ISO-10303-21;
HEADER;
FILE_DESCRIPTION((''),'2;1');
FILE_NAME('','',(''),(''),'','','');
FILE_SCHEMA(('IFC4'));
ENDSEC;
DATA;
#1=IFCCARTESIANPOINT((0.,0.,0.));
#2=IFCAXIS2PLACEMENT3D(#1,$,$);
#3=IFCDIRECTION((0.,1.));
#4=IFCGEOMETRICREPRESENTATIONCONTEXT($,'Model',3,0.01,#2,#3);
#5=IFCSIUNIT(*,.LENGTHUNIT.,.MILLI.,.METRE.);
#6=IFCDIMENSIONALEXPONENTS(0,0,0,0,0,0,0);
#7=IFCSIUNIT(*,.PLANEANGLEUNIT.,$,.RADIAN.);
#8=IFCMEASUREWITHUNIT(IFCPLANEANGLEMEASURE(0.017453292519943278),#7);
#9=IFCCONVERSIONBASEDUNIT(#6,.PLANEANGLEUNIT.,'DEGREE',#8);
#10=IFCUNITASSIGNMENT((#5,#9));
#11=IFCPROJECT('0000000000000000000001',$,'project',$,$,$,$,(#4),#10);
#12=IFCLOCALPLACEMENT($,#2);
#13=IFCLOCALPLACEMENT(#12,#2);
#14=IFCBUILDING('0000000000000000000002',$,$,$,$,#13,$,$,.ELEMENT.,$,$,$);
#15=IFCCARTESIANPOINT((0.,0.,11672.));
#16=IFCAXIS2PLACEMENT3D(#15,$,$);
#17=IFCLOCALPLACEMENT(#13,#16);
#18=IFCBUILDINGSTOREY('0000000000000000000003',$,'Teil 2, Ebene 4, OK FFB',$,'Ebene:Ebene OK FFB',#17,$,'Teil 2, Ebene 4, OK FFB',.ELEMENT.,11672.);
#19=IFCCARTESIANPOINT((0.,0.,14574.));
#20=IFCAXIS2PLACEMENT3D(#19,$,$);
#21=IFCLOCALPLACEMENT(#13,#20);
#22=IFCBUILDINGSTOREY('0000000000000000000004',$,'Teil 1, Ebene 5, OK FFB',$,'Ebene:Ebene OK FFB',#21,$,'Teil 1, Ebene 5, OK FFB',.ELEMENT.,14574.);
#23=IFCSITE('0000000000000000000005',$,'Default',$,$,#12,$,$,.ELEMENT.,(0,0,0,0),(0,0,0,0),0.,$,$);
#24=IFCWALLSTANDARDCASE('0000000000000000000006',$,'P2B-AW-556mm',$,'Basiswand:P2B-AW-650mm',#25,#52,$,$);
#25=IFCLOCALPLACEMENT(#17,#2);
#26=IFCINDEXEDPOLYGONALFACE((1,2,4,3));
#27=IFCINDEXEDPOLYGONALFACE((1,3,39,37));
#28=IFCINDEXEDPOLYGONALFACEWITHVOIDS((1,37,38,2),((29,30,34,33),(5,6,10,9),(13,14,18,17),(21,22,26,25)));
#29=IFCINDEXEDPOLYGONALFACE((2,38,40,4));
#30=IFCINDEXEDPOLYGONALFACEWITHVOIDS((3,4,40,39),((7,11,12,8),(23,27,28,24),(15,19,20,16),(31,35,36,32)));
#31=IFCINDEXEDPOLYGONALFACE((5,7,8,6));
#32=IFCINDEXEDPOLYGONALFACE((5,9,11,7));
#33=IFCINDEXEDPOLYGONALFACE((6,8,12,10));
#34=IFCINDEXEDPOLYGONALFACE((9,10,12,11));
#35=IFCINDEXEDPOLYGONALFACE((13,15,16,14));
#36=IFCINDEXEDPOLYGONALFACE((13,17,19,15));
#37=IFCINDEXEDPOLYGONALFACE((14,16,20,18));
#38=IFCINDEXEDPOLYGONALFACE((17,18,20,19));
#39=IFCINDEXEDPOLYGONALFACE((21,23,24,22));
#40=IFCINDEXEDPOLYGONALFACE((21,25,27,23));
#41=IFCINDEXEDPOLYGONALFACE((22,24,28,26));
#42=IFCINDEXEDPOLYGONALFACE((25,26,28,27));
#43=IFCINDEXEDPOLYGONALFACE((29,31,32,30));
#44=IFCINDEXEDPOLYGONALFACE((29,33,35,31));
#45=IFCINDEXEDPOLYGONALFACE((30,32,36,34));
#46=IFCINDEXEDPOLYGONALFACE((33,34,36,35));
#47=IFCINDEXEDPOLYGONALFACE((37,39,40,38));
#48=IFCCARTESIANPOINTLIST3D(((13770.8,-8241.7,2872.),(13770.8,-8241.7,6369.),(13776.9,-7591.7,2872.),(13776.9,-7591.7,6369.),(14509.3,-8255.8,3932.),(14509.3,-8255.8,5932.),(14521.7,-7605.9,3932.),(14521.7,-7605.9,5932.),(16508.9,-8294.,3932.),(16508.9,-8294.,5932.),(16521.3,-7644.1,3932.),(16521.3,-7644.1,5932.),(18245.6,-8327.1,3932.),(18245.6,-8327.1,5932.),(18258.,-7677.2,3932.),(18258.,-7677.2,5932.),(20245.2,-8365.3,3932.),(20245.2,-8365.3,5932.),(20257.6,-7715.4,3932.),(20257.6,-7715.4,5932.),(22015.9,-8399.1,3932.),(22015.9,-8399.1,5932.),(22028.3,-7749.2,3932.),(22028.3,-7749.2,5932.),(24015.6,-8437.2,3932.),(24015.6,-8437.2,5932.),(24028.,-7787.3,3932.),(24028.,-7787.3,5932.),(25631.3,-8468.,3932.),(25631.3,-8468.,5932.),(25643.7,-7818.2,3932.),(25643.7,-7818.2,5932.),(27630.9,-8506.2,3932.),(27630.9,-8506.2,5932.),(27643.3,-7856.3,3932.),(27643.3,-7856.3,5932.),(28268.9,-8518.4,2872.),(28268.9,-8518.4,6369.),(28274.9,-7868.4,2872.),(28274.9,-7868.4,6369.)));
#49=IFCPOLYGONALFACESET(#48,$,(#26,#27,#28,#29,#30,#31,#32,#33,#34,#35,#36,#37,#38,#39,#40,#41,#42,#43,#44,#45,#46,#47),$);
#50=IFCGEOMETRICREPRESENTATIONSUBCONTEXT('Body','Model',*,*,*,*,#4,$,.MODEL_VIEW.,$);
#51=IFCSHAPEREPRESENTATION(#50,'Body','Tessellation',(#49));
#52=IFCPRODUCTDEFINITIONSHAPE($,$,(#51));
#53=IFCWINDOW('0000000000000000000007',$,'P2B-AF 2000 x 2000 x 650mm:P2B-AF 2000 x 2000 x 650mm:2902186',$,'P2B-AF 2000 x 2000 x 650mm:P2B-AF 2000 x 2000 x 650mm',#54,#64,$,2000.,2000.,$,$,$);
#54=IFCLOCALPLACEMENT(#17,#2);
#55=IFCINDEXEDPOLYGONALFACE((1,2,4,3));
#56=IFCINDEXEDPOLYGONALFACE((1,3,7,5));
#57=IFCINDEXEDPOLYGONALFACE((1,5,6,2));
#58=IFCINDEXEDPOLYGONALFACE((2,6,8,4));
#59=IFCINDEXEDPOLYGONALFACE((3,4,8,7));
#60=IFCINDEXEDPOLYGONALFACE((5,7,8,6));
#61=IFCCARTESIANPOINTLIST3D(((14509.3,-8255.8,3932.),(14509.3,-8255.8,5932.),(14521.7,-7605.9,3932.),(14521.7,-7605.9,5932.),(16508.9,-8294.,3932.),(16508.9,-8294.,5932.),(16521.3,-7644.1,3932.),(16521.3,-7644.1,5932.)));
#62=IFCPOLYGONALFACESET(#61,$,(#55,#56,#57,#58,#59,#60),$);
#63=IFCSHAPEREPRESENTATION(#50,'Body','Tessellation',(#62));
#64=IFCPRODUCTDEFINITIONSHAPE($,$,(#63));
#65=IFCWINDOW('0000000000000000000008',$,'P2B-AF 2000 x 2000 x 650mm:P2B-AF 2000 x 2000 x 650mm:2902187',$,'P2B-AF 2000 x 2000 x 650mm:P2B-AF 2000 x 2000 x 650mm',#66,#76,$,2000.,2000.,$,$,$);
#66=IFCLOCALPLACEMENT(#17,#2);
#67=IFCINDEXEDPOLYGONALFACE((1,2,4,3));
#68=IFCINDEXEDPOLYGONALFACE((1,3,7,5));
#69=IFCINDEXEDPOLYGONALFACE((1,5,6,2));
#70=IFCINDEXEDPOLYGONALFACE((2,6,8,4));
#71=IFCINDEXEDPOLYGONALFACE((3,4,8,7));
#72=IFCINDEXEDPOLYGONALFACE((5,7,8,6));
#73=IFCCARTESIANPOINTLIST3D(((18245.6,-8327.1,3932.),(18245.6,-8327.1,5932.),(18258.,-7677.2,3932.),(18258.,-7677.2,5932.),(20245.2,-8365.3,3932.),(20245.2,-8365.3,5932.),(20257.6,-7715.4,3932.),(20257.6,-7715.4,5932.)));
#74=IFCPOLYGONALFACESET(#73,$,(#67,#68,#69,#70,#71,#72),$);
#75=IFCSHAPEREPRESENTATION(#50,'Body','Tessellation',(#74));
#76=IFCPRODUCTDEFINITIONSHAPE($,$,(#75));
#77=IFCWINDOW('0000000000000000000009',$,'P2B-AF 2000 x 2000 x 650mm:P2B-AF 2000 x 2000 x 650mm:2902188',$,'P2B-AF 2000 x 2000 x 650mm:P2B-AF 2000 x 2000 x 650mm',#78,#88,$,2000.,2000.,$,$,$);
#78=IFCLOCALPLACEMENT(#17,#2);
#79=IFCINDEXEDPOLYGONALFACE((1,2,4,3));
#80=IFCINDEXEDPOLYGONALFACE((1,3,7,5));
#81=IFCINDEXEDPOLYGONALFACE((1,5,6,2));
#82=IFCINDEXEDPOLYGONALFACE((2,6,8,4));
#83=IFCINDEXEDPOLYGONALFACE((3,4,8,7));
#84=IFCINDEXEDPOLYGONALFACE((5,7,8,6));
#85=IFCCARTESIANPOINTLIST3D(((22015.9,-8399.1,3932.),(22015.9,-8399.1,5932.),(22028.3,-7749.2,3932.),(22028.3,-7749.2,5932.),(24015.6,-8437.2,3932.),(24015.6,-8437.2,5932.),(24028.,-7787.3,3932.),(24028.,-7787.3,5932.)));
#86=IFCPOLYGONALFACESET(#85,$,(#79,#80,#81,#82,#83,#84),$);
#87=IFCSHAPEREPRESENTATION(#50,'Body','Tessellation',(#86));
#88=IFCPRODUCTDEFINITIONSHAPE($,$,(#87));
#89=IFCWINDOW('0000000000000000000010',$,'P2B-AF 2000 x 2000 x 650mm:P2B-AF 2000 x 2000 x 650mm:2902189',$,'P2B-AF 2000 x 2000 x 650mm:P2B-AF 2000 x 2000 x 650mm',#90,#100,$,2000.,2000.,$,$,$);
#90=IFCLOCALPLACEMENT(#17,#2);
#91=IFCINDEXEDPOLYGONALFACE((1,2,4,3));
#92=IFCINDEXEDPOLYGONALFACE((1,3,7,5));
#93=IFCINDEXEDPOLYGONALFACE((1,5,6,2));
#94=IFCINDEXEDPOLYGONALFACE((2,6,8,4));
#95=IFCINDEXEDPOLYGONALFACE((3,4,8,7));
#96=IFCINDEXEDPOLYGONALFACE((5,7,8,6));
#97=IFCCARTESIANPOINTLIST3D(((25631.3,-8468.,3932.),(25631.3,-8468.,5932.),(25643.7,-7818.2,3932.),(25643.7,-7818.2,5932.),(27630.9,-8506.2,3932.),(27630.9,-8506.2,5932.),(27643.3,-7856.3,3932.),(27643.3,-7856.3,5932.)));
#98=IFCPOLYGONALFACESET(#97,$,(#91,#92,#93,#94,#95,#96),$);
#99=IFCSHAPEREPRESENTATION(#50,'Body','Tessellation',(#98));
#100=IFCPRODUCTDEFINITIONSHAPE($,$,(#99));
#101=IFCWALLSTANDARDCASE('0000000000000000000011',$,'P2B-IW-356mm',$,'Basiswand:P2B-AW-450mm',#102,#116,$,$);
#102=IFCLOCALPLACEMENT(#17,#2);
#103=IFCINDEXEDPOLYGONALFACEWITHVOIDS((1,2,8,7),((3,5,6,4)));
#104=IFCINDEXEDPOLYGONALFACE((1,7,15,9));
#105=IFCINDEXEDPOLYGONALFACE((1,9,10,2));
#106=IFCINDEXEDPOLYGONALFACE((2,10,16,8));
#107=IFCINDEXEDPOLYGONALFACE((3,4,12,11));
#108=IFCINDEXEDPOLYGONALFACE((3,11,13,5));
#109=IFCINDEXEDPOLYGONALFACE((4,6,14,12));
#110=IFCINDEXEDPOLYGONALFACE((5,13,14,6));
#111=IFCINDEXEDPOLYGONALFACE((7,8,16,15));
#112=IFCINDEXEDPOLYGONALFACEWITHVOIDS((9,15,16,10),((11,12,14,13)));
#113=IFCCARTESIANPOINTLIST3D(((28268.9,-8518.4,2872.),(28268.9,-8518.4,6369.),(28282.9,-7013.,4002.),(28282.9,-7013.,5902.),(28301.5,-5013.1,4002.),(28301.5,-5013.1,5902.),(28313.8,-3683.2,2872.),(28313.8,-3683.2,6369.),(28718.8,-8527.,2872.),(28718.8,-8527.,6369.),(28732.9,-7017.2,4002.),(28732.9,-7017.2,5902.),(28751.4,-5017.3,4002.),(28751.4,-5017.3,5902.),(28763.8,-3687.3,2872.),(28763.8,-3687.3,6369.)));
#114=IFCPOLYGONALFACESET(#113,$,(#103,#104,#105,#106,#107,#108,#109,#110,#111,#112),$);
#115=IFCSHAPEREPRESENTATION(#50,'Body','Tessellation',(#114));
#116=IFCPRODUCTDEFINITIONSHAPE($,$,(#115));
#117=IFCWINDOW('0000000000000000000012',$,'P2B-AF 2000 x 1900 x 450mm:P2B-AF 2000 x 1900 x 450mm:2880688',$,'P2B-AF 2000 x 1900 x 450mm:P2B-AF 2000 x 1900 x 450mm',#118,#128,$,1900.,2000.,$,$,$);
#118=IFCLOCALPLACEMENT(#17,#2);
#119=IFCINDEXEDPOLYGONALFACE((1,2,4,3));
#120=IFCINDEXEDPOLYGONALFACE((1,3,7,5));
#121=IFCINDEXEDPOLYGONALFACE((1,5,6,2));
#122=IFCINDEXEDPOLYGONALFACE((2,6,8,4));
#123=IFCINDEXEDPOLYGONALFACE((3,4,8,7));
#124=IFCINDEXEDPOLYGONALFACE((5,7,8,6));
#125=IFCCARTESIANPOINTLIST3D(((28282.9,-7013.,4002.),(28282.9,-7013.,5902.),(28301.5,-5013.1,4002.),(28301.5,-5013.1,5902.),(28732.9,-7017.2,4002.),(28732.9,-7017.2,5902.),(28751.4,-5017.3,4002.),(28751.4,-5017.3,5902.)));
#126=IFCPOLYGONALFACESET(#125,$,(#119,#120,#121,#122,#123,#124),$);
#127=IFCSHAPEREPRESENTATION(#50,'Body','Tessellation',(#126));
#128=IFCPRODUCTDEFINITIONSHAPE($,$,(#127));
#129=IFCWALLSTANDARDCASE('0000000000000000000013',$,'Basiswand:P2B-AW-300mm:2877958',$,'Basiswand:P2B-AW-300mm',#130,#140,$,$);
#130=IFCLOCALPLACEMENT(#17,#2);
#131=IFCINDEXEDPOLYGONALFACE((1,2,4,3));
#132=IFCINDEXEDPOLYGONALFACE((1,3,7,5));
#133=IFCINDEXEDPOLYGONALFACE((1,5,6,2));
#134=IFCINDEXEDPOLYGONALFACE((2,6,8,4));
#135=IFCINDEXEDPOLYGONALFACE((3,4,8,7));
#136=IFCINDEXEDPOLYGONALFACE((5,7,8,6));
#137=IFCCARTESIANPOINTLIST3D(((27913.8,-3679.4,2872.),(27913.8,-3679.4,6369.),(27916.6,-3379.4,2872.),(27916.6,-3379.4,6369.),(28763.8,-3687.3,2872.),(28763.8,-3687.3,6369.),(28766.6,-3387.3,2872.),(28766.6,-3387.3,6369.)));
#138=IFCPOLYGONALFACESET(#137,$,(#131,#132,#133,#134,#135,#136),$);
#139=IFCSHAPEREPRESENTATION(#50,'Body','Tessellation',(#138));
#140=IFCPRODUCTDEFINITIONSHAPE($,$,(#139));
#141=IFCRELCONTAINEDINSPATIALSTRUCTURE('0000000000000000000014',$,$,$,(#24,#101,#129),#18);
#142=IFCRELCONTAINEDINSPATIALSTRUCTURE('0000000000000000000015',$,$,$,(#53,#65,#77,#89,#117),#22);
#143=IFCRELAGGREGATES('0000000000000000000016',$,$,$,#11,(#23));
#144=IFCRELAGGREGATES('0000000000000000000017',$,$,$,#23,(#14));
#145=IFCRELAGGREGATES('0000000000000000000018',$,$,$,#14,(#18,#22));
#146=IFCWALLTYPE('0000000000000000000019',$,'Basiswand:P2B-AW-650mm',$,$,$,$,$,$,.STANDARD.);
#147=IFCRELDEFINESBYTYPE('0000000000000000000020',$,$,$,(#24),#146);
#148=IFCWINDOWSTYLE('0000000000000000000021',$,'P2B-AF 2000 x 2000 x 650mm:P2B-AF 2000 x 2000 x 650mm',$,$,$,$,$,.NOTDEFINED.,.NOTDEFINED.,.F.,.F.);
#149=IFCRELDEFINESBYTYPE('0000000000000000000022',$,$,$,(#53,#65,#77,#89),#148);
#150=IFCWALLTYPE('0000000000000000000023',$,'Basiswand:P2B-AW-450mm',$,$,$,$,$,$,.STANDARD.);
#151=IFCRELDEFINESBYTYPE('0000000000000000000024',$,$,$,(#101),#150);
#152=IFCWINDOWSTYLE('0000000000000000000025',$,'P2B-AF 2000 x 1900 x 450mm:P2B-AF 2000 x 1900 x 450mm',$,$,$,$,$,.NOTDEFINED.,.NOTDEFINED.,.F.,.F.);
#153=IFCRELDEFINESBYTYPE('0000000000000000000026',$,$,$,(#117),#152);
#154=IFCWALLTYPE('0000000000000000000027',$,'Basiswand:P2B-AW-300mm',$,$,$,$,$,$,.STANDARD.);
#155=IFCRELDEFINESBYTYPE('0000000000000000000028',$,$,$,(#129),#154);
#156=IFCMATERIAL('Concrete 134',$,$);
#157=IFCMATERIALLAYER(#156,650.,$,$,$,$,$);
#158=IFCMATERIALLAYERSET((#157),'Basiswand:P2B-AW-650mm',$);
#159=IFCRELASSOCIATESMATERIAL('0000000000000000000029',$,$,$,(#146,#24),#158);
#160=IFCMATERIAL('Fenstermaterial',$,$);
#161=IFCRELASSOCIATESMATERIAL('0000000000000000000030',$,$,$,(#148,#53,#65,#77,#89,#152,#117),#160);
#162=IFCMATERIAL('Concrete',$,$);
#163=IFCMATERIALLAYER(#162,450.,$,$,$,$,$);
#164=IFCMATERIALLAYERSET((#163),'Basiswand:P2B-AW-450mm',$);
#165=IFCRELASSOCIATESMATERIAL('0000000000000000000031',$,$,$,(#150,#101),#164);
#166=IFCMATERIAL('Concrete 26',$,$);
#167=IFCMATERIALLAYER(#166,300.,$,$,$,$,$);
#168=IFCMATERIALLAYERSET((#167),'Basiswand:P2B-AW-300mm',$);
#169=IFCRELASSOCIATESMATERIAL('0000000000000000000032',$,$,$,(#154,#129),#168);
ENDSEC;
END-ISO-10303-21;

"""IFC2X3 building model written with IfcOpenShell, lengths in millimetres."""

from ifc_helpers import new_model, entity, si_unit, converted_unit, direction, frame, frame_2d, origin, origin_2d_with_axis, place, context, subcontext, project, spatial, polyline, rectangle, outline, extrude, source, transform, mapped, material, layer, layer_set, layer_usage, type_object, type_shapes, element, fill, save


model = new_model("IFC2X3")

# Units and contexts
model_context = context("Model", 3, precision=0.01, world=origin(), true_north=direction((0.0, 1.0)))
body_context = subcontext(model_context, "Body", "Model", "MODEL_VIEW")
ifc_project = project(units=[si_unit("LENGTHUNIT", "METRE", prefix="MILLI"), converted_unit("PLANEANGLEUNIT", "DEGREE", entity("IfcPlaneAngleMeasure", 0.017453292519943278), si_unit("PLANEANGLEUNIT", "RADIAN"), dimensions=[0, 0, 0, 0, 0, 0, 0])], contexts=[model_context])

# Site, building, storey
site_placement = place(None, origin())
site = spatial("IfcSite", under=ifc_project, at=site_placement, Name="Default", CompositionType="ELEMENT", RefLatitude=(0, 0, 0, 0), RefLongitude=(0, 0, 0, 0), RefElevation=0.0)
building_placement = place(site_placement, origin())
building = spatial("IfcBuilding", under=site, at=building_placement, CompositionType="ELEMENT")
storey_1_placement = place(building_placement, frame((0.0, 0.0, 11672.0)))
storey_1 = spatial("IfcBuildingStorey", under=building, at=storey_1_placement, Name="Teil 2, Ebene 4, OK FFB", ObjectType="Ebene:Ebene OK FFB", LongName="Teil 2, Ebene 4, OK FFB", CompositionType="ELEMENT", Elevation=11672.0)

# Shared definitions
storey_2_placement = place(building_placement, frame((0.0, 0.0, 14574.0)))
storey_2 = spatial("IfcBuildingStorey", under=building, at=storey_2_placement, Name="Teil 1, Ebene 5, OK FFB", ObjectType="Ebene:Ebene OK FFB", LongName="Teil 1, Ebene 5, OK FFB", CompositionType="ELEMENT", Elevation=14574.0)

# Wall, openings, windows
ifc_material_1 = material(Name="Concrete 134")
ifc_layer_1 = layer(ifc_material_1, 650.0)
ifc_layer_set_1 = layer_set([ifc_layer_1], Name="Basiswand:P2B-AW-650mm")
ifc_layer_usage_1 = layer_usage(ifc_layer_set_1, "AXIS2", "NEGATIVE", 325.0)
wall_type_1 = type_object("IfcWallType", Name="Basiswand:P2B-AW-650mm", PredefinedType="STANDARD", material=ifc_layer_set_1)
wall_1_placement = place(storey_1_placement, frame((28275.1, -8193.4, 2872.0), z_axis=(0.0, 0.0, 1.0), x_axis=(-0.999818, 0.019077, 0.0)))
wall_1 = element("IfcWallStandardCase", 1, at=wall_1_placement, inside=storey_1, type_object=wall_type_1, material=ifc_layer_usage_1, Name="P2B-AW-556mm", ObjectType="Basiswand:P2B-AW-650mm", context=body_context, shape_type="SweptSolid", body=[
    extrude(outline(polyline([(14507.1, -325.0), (14500.7, 325.0), (0.0, 325.0), (6.4, -325.0), (3407.1, -325.0), (3707.1, -325.0), (14507.1, -325.0)])), origin(), (0.0, 0.0, 1.0), 3497.0),
])
opening_1_placement = place(wall_1_placement, frame((28426.2, -7652.5, 30.0), z_axis=(0.0, 0.0, 1.0), x_axis=(-0.999818, -0.019077, 0.0)))
opening_1 = element("IfcOpeningElement", 2, at=opening_1_placement, cuts=wall_1, ObjectType="Opening", context=body_context, shape_type="SweptSolid", body=[
    extrude(rectangle(XDim=2000.0, YDim=2000.0, at=origin_2d_with_axis()), frame((15521.5, -7625.0, 2030.0), z_axis=(-0.019077, -0.999818, 0.0), x_axis=(0.0, 0.0, -1.0)), (0.0, 0.0, 1.0), 650.0),
])
opening_2_placement = place(wall_1_placement, frame((28426.2, -7652.5, 30.0), z_axis=(0.0, 0.0, 1.0), x_axis=(-0.999818, -0.019077, 0.0)))
opening_2 = element("IfcOpeningElement", 3, at=opening_2_placement, cuts=wall_1, ObjectType="Opening", context=body_context, shape_type="SweptSolid", body=[
    extrude(rectangle(XDim=2000.0, YDim=2000.0, at=origin_2d_with_axis()), frame((19257.8, -7696.3, 2030.0), z_axis=(-0.019077, -0.999818, 0.0), x_axis=(0.0, 0.0, -1.0)), (0.0, 0.0, 1.0), 650.0),
])
opening_3_placement = place(wall_1_placement, frame((28426.2, -7652.5, 30.0), z_axis=(0.0, 0.0, 1.0), x_axis=(-0.999818, -0.019077, 0.0)))
opening_3 = element("IfcOpeningElement", 4, at=opening_3_placement, cuts=wall_1, ObjectType="Opening", context=body_context, shape_type="SweptSolid", body=[
    extrude(rectangle(XDim=2000.0, YDim=2000.0, at=frame_2d((0.0, 0.0), x_axis=(1.0, 0.0))), frame((23028.1, -7768.3, 2030.0), z_axis=(-0.019077, -0.999818, 0.0), x_axis=(0.0, 0.0, -1.0)), (0.0, 0.0, 1.0), 650.0),
])
opening_4_placement = place(wall_1_placement, frame((28426.2, -7652.5, 30.0), z_axis=(0.0, 0.0, 1.0), x_axis=(-0.999818, -0.019077, 0.0)))
opening_4 = element("IfcOpeningElement", 5, at=opening_4_placement, cuts=wall_1, ObjectType="Opening", context=body_context, shape_type="SweptSolid", body=[
    extrude(rectangle(XDim=2000.0, YDim=2000.0, at=frame_2d((0.0, 0.0), x_axis=(1.0, 0.0))), frame((26643.5, -7837.2, 2030.0), z_axis=(-0.019077, -0.999818, 0.0), x_axis=(0.0, 0.0, -1.0)), (0.0, 0.0, 1.0), 650.0),
])
ifc_material_2 = material(Name="Fenstermaterial")
window_style_1 = type_object("IfcWindowStyle", Name="P2B-AF 2000 x 2000 x 650mm:P2B-AF 2000 x 2000 x 650mm", ConstructionType="NOTDEFINED", OperationType="NOTDEFINED", ParameterTakesPrecedence=False, Sizeable=False, material=ifc_material_2)
shared_shape_1 = source(origin(), body_context, "Body", "SweptSolid", [
    extrude(rectangle(XDim=650.0, YDim=2000.0, at=frame_2d((0.0, 0.0), x_axis=(1.0, 0.0))), frame((1000.0, -325.0, 0.0), z_axis=(0.0, 0.0, 1.0), x_axis=(0.0, 1.0, 0.0)), (0.0, 0.0, 1.0), 2000.0),
])
type_shapes(window_style_1, [shared_shape_1])
window_1_placement = place(opening_1_placement, frame((16508.9, -8294.0, 1030.0), z_axis=(0.0, 0.0, 1.0), x_axis=(-0.999818, 0.019077, 0.0)))
window_1 = element("IfcWindow", 6, at=window_1_placement, inside=storey_2, type_object=window_style_1, material=ifc_material_2, Name="P2B-AF 2000 x 2000 x 650mm:P2B-AF 2000 x 2000 x 650mm:2902186", ObjectType="P2B-AF 2000 x 2000 x 650mm:P2B-AF 2000 x 2000 x 650mm", OverallHeight=2000.0, OverallWidth=2000.0, context=body_context, shape_type="MappedRepresentation", body=[
    mapped(shared_shape_1, transform((0.0, 0.0, 0.0), scale=1.0)),
])
fill(opening_1, window_1)
window_2_placement = place(opening_2_placement, frame((20245.2, -8365.3, 1030.0), z_axis=(0.0, 0.0, 1.0), x_axis=(-0.999818, 0.019077, 0.0)))
window_2 = element("IfcWindow", 7, at=window_2_placement, inside=storey_2, type_object=window_style_1, material=ifc_material_2, Name="P2B-AF 2000 x 2000 x 650mm:P2B-AF 2000 x 2000 x 650mm:2902187", ObjectType="P2B-AF 2000 x 2000 x 650mm:P2B-AF 2000 x 2000 x 650mm", OverallHeight=2000.0, OverallWidth=2000.0, context=body_context, shape_type="MappedRepresentation", body=[
    mapped(shared_shape_1, transform((0.0, 0.0, 0.0), scale=1.0)),
])
fill(opening_2, window_2)
window_3_placement = place(opening_3_placement, frame((24015.6, -8437.2, 1030.0), z_axis=(0.0, 0.0, 1.0), x_axis=(-0.999818, 0.019077, 0.0)))
window_3 = element("IfcWindow", 8, at=window_3_placement, inside=storey_2, type_object=window_style_1, material=ifc_material_2, Name="P2B-AF 2000 x 2000 x 650mm:P2B-AF 2000 x 2000 x 650mm:2902188", ObjectType="P2B-AF 2000 x 2000 x 650mm:P2B-AF 2000 x 2000 x 650mm", OverallHeight=2000.0, OverallWidth=2000.0, context=body_context, shape_type="MappedRepresentation", body=[
    mapped(shared_shape_1, transform((0.0, 0.0, 0.0), scale=1.0)),
])
fill(opening_3, window_3)
window_4_placement = place(opening_4_placement, frame((27630.9, -8506.2, 1030.0), z_axis=(0.0, 0.0, 1.0), x_axis=(-0.999818, 0.019077, 0.0)))
window_4 = element("IfcWindow", 9, at=window_4_placement, inside=storey_2, type_object=window_style_1, material=ifc_material_2, Name="P2B-AF 2000 x 2000 x 650mm:P2B-AF 2000 x 2000 x 650mm:2902189", ObjectType="P2B-AF 2000 x 2000 x 650mm:P2B-AF 2000 x 2000 x 650mm", OverallHeight=2000.0, OverallWidth=2000.0, context=body_context, shape_type="MappedRepresentation", body=[
    mapped(shared_shape_1, transform((0.0, 0.0, 0.0), scale=1.0)),
])
fill(opening_4, window_4)

# Wall, opening, window
ifc_material_3 = material(Name="Concrete")
ifc_layer_2 = layer(ifc_material_3, 450.0)
ifc_layer_set_2 = layer_set([ifc_layer_2], Name="Basiswand:P2B-AW-450mm")
ifc_layer_usage_2 = layer_usage(ifc_layer_set_2, "AXIS2", "NEGATIVE", 225.0)
wall_type_2 = type_object("IfcWallType", Name="Basiswand:P2B-AW-450mm", PredefinedType="STANDARD", material=ifc_layer_set_2)
wall_2_placement = place(storey_1_placement, frame((28538.8, -3685.2, 2872.0), z_axis=(0.0, 0.0, 1.0), x_axis=(-0.009291, -0.999957, 0.0)))
wall_2 = element("IfcWallStandardCase", 10, at=wall_2_placement, inside=storey_1, type_object=wall_type_2, material=ifc_layer_usage_2, Name="P2B-IW-356mm", ObjectType="Basiswand:P2B-AW-450mm", context=body_context, shape_type="SweptSolid", body=[
    extrude(outline(polyline([(4835.4, -225.0), (4839.8, 225.0), (0.0, 225.0), (0.0, -225.0), (350.0, -225.0), (4185.4, -225.0), (4835.4, -225.0)])), origin(), (0.0, 0.0, 1.0), 3497.0),
])
opening_5_placement = place(wall_2_placement, frame((-3419.9, -28571.8, 30.0), z_axis=(0.0, 0.0, 1.0), x_axis=(-0.009291, 0.999957, 0.0)))
opening_5 = element("IfcOpeningElement", 11, at=opening_5_placement, cuts=wall_2, ObjectType="Opening", context=body_context, shape_type="SweptSolid", body=[
    extrude(rectangle(XDim=1900.0, YDim=2000.0, at=origin_2d_with_axis()), frame((28292.2, -6013.1, 2050.0), z_axis=(0.999957, -0.009291, 0.0), x_axis=(0.0, 0.0, -1.0)), (0.0, 0.0, 1.0), 450.0),
])
window_style_2 = type_object("IfcWindowStyle", Name="P2B-AF 2000 x 1900 x 450mm:P2B-AF 2000 x 1900 x 450mm", ConstructionType="NOTDEFINED", OperationType="NOTDEFINED", ParameterTakesPrecedence=False, Sizeable=False, material=ifc_material_2)
shared_shape_2 = source(origin(), body_context, "Body", "SweptSolid", [
    extrude(rectangle(XDim=450.0, YDim=2000.0, at=frame_2d((0.0, 0.0), x_axis=(1.0, 0.0))), frame((1000.0, 225.0, 0.0), z_axis=(0.0, 0.0, 1.0), x_axis=(0.0, 1.0, 0.0)), (0.0, 0.0, 1.0), 1900.0),
])
type_shapes(window_style_2, [shared_shape_2])
window_5_placement = place(opening_5_placement, frame((28732.9, -7017.2, 1100.0), z_axis=(0.0, 0.0, 1.0), x_axis=(0.009291, 0.999957, 0.0)))
window_5 = element("IfcWindow", 12, at=window_5_placement, inside=storey_2, type_object=window_style_2, material=ifc_material_2, Name="P2B-AF 2000 x 1900 x 450mm:P2B-AF 2000 x 1900 x 450mm:2880688", ObjectType="P2B-AF 2000 x 1900 x 450mm:P2B-AF 2000 x 1900 x 450mm", OverallHeight=1900.0, OverallWidth=2000.0, context=body_context, shape_type="MappedRepresentation", body=[
    mapped(shared_shape_2, transform((0.0, 0.0, 0.0), scale=1.0)),
])
fill(opening_5, window_5)

# Wall
ifc_material_4 = material(Name="Concrete 26")
ifc_layer_3 = layer(ifc_material_4, 300.0)
ifc_layer_set_3 = layer_set([ifc_layer_3], Name="Basiswand:P2B-AW-300mm")
ifc_layer_usage_3 = layer_usage(ifc_layer_set_3, "AXIS2", "POSITIVE", -150.0)
wall_type_3 = type_object("IfcWallType", Name="Basiswand:P2B-AW-300mm", PredefinedType="STANDARD", material=ifc_layer_set_3)
wall_3_placement = place(storey_1_placement, frame((27915.2, -3529.4, 2872.0), z_axis=(0.0, 0.0, 1.0), x_axis=(0.999957, -0.00929, 0.0)))
element("IfcWallStandardCase", 13, at=wall_3_placement, inside=storey_1, type_object=wall_type_3, material=ifc_layer_usage_3, Name="Basiswand:P2B-AW-300mm:2877958", ObjectType="Basiswand:P2B-AW-300mm", context=body_context, shape_type="SweptSolid", body=[
    extrude(rectangle(XDim=850.0, YDim=300.0, at=frame_2d((425.0, 0.0), x_axis=(-1.0, 0.0))), origin(), (0.0, 0.0, 1.0), 3497.0),
])

save(model, "model.ifc")
